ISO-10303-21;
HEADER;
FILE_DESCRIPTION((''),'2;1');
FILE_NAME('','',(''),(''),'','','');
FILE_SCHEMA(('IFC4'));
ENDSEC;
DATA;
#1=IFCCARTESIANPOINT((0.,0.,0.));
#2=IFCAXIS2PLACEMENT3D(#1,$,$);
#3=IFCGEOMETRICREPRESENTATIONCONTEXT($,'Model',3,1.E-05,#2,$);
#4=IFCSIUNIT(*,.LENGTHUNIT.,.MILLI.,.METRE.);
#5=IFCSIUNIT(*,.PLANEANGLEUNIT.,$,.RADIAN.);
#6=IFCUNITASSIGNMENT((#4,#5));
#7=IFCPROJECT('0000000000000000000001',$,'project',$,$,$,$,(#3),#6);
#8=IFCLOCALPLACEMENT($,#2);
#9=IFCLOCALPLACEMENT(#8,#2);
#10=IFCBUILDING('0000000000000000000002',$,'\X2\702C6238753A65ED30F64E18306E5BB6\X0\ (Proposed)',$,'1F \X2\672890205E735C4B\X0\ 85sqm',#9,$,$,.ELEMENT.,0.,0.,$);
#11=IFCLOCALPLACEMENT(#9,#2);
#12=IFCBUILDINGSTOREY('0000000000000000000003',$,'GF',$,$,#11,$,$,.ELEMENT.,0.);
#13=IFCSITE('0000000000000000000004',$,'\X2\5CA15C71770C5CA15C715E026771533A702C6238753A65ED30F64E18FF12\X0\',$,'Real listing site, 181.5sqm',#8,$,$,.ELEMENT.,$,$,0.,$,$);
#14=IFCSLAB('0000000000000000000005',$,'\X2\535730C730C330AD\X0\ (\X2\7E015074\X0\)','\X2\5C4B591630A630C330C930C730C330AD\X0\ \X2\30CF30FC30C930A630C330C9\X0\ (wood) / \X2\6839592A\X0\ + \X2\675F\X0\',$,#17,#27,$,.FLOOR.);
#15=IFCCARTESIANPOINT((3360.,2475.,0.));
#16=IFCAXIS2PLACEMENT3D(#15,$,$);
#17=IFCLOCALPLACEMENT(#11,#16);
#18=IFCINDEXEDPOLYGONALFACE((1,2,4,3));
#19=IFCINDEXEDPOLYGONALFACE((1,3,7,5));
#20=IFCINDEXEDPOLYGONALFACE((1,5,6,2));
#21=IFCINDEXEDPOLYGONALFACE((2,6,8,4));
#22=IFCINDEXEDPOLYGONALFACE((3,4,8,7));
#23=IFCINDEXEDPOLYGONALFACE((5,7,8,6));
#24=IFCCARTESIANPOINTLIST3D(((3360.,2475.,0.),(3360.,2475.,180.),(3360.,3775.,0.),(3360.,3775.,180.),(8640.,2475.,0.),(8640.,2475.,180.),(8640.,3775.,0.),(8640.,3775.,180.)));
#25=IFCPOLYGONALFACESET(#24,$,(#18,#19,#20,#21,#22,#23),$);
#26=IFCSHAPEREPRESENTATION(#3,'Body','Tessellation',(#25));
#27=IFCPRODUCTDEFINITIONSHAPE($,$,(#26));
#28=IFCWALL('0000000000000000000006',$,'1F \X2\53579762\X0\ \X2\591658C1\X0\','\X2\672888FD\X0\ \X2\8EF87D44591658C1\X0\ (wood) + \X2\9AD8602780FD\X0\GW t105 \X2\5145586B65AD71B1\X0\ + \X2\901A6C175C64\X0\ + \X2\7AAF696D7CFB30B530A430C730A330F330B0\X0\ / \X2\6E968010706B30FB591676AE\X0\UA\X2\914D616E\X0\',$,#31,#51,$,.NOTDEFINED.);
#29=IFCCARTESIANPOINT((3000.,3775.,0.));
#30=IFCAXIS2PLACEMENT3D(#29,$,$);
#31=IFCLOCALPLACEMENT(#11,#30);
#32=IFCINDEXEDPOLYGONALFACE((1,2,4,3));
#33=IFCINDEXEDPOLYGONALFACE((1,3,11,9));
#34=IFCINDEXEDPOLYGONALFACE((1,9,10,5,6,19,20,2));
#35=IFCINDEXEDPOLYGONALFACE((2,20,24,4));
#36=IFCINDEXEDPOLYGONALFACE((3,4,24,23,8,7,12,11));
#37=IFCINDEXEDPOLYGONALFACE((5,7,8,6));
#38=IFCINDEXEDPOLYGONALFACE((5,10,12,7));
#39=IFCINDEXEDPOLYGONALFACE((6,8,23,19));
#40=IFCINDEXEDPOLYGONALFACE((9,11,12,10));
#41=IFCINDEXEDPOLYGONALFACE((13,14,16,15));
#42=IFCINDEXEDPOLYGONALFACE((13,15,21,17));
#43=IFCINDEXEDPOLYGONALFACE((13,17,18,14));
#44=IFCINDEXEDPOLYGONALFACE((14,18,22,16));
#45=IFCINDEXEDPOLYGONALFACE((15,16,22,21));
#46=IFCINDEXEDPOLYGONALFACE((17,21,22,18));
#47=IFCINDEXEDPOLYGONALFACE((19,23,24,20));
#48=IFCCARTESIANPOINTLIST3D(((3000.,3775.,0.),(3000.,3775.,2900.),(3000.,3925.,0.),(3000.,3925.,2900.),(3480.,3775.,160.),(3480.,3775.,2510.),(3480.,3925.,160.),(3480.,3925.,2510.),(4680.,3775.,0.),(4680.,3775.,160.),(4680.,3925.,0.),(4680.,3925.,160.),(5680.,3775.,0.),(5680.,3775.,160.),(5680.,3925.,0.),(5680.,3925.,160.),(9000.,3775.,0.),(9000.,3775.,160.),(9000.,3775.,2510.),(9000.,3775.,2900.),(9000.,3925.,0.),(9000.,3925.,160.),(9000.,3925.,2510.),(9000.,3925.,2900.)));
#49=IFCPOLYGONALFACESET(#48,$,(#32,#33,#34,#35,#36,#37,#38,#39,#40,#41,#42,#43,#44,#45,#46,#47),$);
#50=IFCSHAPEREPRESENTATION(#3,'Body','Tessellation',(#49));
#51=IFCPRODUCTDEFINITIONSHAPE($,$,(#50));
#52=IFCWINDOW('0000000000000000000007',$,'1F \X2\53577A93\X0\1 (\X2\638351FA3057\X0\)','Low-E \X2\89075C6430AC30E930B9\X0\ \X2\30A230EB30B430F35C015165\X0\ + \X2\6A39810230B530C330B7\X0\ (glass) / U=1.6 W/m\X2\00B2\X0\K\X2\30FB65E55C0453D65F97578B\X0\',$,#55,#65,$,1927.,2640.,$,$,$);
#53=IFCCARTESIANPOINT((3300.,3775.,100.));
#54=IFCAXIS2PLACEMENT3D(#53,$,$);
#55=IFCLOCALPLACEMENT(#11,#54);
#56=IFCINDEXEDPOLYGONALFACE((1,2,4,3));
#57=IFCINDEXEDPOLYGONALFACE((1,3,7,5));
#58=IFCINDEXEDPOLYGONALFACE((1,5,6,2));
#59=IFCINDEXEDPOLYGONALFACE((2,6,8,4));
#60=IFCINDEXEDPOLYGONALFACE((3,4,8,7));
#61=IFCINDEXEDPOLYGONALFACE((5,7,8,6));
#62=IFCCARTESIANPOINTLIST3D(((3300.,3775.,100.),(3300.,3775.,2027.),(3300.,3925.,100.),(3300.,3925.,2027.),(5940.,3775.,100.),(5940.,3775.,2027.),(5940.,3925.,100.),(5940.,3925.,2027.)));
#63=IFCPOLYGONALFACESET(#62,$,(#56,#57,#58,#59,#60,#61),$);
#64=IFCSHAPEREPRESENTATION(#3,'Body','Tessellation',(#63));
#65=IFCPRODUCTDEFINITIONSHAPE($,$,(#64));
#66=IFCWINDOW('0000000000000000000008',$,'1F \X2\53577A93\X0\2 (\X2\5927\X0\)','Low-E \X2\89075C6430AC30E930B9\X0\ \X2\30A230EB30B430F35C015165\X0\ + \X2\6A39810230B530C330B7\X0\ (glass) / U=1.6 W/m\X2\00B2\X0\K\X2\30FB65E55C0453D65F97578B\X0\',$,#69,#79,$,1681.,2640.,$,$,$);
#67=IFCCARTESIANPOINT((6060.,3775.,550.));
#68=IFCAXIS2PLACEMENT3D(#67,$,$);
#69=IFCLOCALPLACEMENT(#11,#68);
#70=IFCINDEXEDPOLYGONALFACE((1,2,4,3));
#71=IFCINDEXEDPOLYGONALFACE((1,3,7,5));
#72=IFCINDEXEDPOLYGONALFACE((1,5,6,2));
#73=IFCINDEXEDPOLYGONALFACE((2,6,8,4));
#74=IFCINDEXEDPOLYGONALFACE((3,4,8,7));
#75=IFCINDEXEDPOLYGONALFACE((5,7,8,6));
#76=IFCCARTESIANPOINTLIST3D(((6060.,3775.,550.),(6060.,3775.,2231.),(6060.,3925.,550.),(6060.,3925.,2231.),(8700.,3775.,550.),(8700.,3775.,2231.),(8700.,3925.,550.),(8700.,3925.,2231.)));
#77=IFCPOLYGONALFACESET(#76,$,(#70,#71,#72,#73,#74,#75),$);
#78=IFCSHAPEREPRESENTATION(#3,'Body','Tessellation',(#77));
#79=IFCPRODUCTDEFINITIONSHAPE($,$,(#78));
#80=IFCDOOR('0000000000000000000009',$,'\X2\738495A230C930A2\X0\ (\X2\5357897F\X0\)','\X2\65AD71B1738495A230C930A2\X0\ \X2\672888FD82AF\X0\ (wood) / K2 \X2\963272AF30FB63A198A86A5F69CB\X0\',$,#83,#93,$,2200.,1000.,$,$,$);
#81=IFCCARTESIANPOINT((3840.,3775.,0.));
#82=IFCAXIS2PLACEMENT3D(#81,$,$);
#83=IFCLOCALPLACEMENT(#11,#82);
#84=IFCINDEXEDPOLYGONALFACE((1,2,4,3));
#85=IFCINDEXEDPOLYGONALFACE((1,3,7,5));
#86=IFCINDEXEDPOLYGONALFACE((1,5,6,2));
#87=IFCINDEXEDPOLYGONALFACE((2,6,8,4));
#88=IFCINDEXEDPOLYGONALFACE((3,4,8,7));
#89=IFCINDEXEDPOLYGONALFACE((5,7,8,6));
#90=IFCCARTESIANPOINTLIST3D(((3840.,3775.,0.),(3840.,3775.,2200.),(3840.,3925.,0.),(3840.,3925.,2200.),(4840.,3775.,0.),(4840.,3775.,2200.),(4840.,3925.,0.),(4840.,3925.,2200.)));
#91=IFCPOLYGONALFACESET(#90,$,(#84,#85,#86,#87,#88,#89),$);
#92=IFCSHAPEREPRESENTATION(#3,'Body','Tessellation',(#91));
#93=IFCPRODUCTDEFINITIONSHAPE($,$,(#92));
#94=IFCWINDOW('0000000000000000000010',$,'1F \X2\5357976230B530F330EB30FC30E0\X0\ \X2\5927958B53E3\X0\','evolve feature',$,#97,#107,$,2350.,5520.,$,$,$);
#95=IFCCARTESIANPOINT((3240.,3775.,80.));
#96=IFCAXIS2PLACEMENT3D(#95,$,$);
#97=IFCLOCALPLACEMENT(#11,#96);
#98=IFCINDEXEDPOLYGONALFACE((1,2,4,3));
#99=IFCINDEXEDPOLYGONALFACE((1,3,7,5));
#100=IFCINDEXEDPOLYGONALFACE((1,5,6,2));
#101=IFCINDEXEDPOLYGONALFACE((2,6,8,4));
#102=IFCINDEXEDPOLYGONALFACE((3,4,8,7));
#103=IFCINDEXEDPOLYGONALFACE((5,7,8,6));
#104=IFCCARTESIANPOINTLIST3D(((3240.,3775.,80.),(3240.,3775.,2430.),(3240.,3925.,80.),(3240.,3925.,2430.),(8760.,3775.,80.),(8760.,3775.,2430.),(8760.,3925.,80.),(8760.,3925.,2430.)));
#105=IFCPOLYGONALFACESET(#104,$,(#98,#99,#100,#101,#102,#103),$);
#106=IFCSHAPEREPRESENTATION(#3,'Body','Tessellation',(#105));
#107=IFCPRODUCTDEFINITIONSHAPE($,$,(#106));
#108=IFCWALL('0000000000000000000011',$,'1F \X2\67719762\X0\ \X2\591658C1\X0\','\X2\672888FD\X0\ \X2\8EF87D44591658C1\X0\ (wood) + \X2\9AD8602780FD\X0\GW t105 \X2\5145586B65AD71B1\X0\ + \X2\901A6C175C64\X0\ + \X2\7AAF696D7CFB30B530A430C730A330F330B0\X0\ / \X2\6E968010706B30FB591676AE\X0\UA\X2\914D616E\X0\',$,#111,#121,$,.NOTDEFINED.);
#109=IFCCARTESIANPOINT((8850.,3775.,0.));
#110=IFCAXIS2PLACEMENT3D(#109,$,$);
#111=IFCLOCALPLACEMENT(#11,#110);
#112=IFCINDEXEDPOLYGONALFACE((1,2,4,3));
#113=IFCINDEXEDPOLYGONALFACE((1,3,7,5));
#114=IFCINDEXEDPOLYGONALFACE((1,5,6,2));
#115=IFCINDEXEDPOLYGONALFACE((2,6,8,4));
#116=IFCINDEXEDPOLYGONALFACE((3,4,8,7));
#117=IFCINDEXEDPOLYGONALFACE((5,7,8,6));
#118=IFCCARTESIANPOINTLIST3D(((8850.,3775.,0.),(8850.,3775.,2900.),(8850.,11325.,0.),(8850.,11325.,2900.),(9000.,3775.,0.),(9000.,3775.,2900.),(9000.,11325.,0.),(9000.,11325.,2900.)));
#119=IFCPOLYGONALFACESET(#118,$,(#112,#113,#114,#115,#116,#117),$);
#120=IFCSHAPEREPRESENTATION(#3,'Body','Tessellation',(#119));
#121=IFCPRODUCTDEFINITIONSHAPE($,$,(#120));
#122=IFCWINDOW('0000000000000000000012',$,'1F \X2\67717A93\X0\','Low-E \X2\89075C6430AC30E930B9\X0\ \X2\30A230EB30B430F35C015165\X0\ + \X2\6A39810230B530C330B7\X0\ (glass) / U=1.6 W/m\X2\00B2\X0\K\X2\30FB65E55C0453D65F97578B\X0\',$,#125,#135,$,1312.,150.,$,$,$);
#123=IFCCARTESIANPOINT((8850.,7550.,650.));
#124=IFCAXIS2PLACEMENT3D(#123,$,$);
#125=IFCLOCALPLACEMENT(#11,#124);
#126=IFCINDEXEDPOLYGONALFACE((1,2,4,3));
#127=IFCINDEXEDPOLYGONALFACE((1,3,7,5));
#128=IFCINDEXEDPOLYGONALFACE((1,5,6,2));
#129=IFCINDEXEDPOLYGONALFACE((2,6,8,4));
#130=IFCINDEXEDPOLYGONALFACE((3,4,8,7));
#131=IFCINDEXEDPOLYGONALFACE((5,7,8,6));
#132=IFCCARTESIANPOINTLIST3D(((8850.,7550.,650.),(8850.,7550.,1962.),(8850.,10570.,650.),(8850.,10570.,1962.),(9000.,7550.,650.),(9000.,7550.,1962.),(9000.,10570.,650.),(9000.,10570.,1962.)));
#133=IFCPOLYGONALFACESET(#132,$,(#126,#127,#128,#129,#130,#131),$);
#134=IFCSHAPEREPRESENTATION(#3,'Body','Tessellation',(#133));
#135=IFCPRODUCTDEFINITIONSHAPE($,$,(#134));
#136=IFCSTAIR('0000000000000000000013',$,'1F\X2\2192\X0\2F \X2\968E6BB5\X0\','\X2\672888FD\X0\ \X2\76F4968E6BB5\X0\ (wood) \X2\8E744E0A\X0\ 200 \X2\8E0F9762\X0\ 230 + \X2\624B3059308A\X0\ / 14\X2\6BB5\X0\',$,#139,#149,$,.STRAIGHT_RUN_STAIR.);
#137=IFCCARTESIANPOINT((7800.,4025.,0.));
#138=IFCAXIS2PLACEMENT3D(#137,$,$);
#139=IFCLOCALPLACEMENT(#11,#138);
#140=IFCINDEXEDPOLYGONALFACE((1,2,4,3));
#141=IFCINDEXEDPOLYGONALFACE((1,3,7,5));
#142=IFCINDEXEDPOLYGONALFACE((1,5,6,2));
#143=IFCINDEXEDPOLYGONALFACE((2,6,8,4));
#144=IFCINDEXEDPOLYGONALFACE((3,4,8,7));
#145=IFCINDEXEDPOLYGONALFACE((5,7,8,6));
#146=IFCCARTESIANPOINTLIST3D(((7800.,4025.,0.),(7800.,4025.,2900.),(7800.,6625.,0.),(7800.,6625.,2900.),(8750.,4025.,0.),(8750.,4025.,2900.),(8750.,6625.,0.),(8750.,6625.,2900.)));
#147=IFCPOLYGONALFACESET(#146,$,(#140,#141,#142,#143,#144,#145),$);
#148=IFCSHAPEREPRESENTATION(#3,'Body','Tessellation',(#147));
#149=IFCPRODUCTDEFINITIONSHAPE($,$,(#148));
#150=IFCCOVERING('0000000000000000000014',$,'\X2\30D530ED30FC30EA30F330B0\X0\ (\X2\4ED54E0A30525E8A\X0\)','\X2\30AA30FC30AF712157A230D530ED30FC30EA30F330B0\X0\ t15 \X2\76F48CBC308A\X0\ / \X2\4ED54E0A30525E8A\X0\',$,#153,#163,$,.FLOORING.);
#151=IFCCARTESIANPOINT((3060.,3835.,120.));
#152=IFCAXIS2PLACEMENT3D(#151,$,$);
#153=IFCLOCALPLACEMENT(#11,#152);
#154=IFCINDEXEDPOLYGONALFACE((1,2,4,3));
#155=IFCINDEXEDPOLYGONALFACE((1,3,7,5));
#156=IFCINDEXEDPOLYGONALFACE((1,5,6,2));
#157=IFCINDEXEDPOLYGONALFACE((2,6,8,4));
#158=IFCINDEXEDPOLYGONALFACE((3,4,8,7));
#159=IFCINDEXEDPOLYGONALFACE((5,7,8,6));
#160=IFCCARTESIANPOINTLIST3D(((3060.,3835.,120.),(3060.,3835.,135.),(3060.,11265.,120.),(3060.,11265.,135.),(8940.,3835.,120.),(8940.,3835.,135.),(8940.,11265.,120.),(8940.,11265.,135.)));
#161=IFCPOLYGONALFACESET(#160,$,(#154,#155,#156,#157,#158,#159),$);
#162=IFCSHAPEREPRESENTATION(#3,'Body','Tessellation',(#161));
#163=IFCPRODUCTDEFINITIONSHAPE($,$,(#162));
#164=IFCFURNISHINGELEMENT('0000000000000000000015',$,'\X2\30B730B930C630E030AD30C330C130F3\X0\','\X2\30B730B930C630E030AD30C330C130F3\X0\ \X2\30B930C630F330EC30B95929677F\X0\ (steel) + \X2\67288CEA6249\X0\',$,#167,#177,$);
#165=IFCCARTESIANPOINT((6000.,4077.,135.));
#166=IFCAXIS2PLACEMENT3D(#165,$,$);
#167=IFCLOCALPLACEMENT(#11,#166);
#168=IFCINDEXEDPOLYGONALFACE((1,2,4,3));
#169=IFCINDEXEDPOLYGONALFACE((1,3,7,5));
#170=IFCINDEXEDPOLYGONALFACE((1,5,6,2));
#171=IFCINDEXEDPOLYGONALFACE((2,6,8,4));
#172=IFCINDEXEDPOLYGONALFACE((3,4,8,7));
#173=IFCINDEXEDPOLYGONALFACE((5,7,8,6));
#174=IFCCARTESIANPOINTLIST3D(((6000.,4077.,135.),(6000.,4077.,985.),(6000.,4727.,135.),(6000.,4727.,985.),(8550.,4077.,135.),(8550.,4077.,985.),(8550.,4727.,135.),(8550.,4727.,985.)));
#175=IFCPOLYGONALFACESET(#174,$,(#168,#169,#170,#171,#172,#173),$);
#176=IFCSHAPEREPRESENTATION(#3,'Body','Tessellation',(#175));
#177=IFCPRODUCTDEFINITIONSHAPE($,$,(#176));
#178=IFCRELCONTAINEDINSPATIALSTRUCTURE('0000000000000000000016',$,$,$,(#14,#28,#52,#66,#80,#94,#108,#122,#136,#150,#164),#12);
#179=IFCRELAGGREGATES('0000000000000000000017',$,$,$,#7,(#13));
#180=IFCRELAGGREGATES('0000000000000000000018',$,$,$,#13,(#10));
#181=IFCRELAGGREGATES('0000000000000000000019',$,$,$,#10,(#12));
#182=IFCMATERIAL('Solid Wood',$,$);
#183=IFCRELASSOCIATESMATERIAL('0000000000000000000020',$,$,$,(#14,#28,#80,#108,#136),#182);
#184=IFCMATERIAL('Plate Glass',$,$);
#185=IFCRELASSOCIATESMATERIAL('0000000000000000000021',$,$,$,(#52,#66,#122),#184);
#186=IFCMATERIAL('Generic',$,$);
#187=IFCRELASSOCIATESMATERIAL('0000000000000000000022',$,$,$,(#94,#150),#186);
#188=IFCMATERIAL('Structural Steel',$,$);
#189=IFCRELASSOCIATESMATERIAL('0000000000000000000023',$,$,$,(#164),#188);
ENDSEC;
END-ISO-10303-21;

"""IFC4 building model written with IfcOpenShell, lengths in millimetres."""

from ifc_helpers import new_model, si_unit, frame, frame_2d, origin, place, context, project, spatial, rectangle, extrude, material, element, fill, save


model = new_model("IFC4")

# Units and contexts
model_context = context("Model", 3, precision=1e-05, world=origin())
ifc_project = project(units=[si_unit("LENGTHUNIT", "METRE", prefix="MILLI"), si_unit("PLANEANGLEUNIT", "RADIAN")], contexts=[model_context])

# Site, building, storey
site_placement = place(None, origin())
site = spatial("IfcSite", under=ifc_project, at=site_placement, Name="岡山県岡山市東区瀬戸町旭ヶ丘２", ObjectType="Real listing site, 181.5sqm", CompositionType="ELEMENT", RefElevation=0.0)
building_placement = place(site_placement, origin())
building = spatial("IfcBuilding", under=site, at=building_placement, Name="瀬戸町旭ヶ丘の家 (Proposed)", ObjectType="1F 木造平屋 85sqm", CompositionType="ELEMENT", ElevationOfRefHeight=0.0, ElevationOfTerrain=0.0)
storey_placement = place(building_placement, origin())
storey = spatial("IfcBuildingStorey", under=building, at=storey_placement, Name="GF", CompositionType="ELEMENT", Elevation=0.0)

# Slab
ifc_material_1 = material(Name="Solid Wood")
slab_1_placement = place(storey_placement, frame((3360.0, 2475.0, 0.0)))
element("IfcSlab", 1, at=slab_1_placement, inside=storey, material=ifc_material_1, Name="南デッキ (縁側)", Description="屋外ウッドデッキ ハードウッド (wood) / 根太 + 束", PredefinedType="FLOOR", context=model_context, shape_type="SweptSolid", body=[
    extrude(rectangle(XDim=5280.0, YDim=1300.0, at=frame_2d((2640.0, 650.0))), frame((3360.0, 2475.0, 0.0)), (0.0, 0.0, 1.0), 180.0),
])
ifc_material_2 = material(Name="Generic")

# Wall, openings, windows, door
wall_1_placement = place(storey_placement, frame((3000.0, 3775.0, 0.0)))
wall_1 = element("IfcWall", 2, at=wall_1_placement, inside=storey, material=ifc_material_1, Name="1F 南面 外壁", Description="木製 軸組外壁 (wood) + 高性能GW t105 充填断熱 + 通気層 + 窯業系サイディング / 準耐火・外皮UA配慮", PredefinedType="NOTDEFINED", context=model_context, shape_type="SweptSolid", body=[
    extrude(rectangle(XDim=6000.0, YDim=150.0, at=frame_2d((3000.0, 75.0))), frame((3000.0, 3775.0, 0.0)), (0.0, 0.0, 1.0), 2900.0),
])
opening_1_placement = place(storey_placement, frame((3300.0, 3775.0, 100.0)))
opening_1 = element("IfcOpeningElement", 3, at=opening_1_placement, cuts=wall_1, PredefinedType="NOTDEFINED", context=model_context, shape_type="SweptSolid", body=[
    extrude(rectangle(XDim=2640.0, YDim=150.0, at=frame_2d((1320.0, 75.0))), frame((3300.0, 3775.0, 100.0)), (0.0, 0.0, 1.0), 1927.0),
])
opening_2_placement = place(storey_placement, frame((6060.0, 3775.0, 550.0)))
opening_2 = element("IfcOpeningElement", 4, at=opening_2_placement, cuts=wall_1, PredefinedType="NOTDEFINED", context=model_context, shape_type="SweptSolid", body=[
    extrude(rectangle(XDim=2640.0, YDim=150.0, at=frame_2d((1320.0, 75.0))), frame((6060.0, 3775.0, 550.0)), (0.0, 0.0, 1.0), 1681.0),
])
opening_3_placement = place(storey_placement, frame((3840.0, 3775.0, 0.0)))
opening_3 = element("IfcOpeningElement", 5, at=opening_3_placement, cuts=wall_1, PredefinedType="NOTDEFINED", context=model_context, shape_type="SweptSolid", body=[
    extrude(rectangle(XDim=1000.0, YDim=150.0, at=frame_2d((500.0, 75.0))), frame((3840.0, 3775.0, 0.0)), (0.0, 0.0, 1.0), 2200.0),
])
opening_4_placement = place(storey_placement, frame((3240.0, 3775.0, 80.0)))
opening_4 = element("IfcOpeningElement", 6, at=opening_4_placement, cuts=wall_1, PredefinedType="NOTDEFINED", context=model_context, shape_type="SweptSolid", body=[
    extrude(rectangle(XDim=5520.0, YDim=150.0, at=frame_2d((2760.0, 75.0))), frame((3240.0, 3775.0, 80.0)), (0.0, 0.0, 1.0), 2350.0),
])
ifc_material_3 = material(Name="Plate Glass")
window_1_placement = place(storey_placement, frame((3300.0, 3775.0, 100.0)))
window_1 = element("IfcWindow", 7, at=window_1_placement, inside=storey, material=ifc_material_3, Name="1F 南窓1 (掃出し)", Description="Low-E 複層ガラス アルゴン封入 + 樹脂サッシ (glass) / U=1.6 W/m²K・日射取得型", OverallHeight=1927.0, OverallWidth=2640.0, context=model_context, shape_type="SweptSolid", body=[
    extrude(rectangle(XDim=2640.0, YDim=150.0, at=frame_2d((1320.0, 75.0))), frame((3300.0, 3775.0, 100.0)), (0.0, 0.0, 1.0), 1927.0),
])
fill(opening_1, window_1)
window_2_placement = place(storey_placement, frame((6060.0, 3775.0, 550.0)))
window_2 = element("IfcWindow", 8, at=window_2_placement, inside=storey, material=ifc_material_3, Name="1F 南窓2 (大)", Description="Low-E 複層ガラス アルゴン封入 + 樹脂サッシ (glass) / U=1.6 W/m²K・日射取得型", OverallHeight=1681.0, OverallWidth=2640.0, context=model_context, shape_type="SweptSolid", body=[
    extrude(rectangle(XDim=2640.0, YDim=150.0, at=frame_2d((1320.0, 75.0))), frame((6060.0, 3775.0, 550.0)), (0.0, 0.0, 1.0), 1681.0),
])
fill(opening_2, window_2)
door_placement = place(storey_placement, frame((3840.0, 3775.0, 0.0)))
door = element("IfcDoor", 9, at=door_placement, inside=storey, material=ifc_material_1, Name="玄関ドア (南西)", Description="断熱玄関ドア 木製芯 (wood) / K2 防犯・採風機構", OverallHeight=2200.0, OverallWidth=1000.0, context=model_context, shape_type="SweptSolid", body=[
    extrude(rectangle(XDim=1000.0, YDim=150.0, at=frame_2d((500.0, 75.0))), frame((3840.0, 3775.0, 0.0)), (0.0, 0.0, 1.0), 2200.0),
])
fill(opening_3, door)
window_3_placement = place(storey_placement, frame((3240.0, 3775.0, 80.0)))
window_3 = element("IfcWindow", 10, at=window_3_placement, inside=storey, material=ifc_material_2, Name="1F 南面サンルーム 大開口", Description="evolve feature", OverallHeight=2350.0, OverallWidth=5520.0, context=model_context, shape_type="SweptSolid", body=[
    extrude(rectangle(XDim=5520.0, YDim=150.0, at=frame_2d((2760.0, 75.0))), frame((3240.0, 3775.0, 80.0)), (0.0, 0.0, 1.0), 2350.0),
])
fill(opening_4, window_3)

# Wall, opening, window
wall_2_placement = place(storey_placement, frame((8850.0, 3775.0, 0.0)))
wall_2 = element("IfcWall", 11, at=wall_2_placement, inside=storey, material=ifc_material_1, Name="1F 東面 外壁", Description="木製 軸組外壁 (wood) + 高性能GW t105 充填断熱 + 通気層 + 窯業系サイディング / 準耐火・外皮UA配慮", PredefinedType="NOTDEFINED", context=model_context, shape_type="SweptSolid", body=[
    extrude(rectangle(XDim=150.0, YDim=7550.0, at=frame_2d((75.0, 3775.0))), frame((8850.0, 3775.0, 0.0)), (0.0, 0.0, 1.0), 2900.0),
])
opening_5_placement = place(storey_placement, frame((8850.0, 7550.0, 650.0)))
opening_5 = element("IfcOpeningElement", 12, at=opening_5_placement, cuts=wall_2, PredefinedType="NOTDEFINED", context=model_context, shape_type="SweptSolid", body=[
    extrude(rectangle(XDim=150.0, YDim=3020.0, at=frame_2d((75.0, 1510.0))), frame((8850.0, 7550.0, 650.0)), (0.0, 0.0, 1.0), 1312.0),
])
window_4_placement = place(storey_placement, frame((8850.0, 7550.0, 650.0)))
window_4 = element("IfcWindow", 13, at=window_4_placement, inside=storey, material=ifc_material_3, Name="1F 東窓", Description="Low-E 複層ガラス アルゴン封入 + 樹脂サッシ (glass) / U=1.6 W/m²K・日射取得型", OverallHeight=1312.0, OverallWidth=150.0, context=model_context, shape_type="SweptSolid", body=[
    extrude(rectangle(XDim=150.0, YDim=3020.0, at=frame_2d((75.0, 1510.0))), frame((8850.0, 7550.0, 650.0)), (0.0, 0.0, 1.0), 1312.0),
])
fill(opening_5, window_4)

# Stair
stair_placement = place(storey_placement, frame((7800.0, 4025.0, 0.0)))
element("IfcStair", 14, at=stair_placement, inside=storey, material=ifc_material_1, Name="1F→2F 階段", Description="木製 直階段 (wood) 蹴上 200 踏面 230 + 手すり / 14段", PredefinedType="STRAIGHT_RUN_STAIR", context=model_context, shape_type="SweptSolid", body=[
    extrude(rectangle(XDim=950.0, YDim=2600.0, at=frame_2d((475.0, 1300.0))), frame((7800.0, 4025.0, 0.0)), (0.0, 0.0, 1.0), 2900.0),
])

# Covering
covering_placement = place(storey_placement, frame((3060.0, 3835.0, 120.0)))
element("IfcCovering", 15, at=covering_placement, inside=storey, material=ifc_material_2, Name="フローリング (仕上げ床)", Description="オーク無垢フローリング t15 直貼り / 仕上げ床", PredefinedType="FLOORING", context=model_context, shape_type="SweptSolid", body=[
    extrude(rectangle(XDim=5880.0, YDim=7430.0, at=frame_2d((2940.0, 3715.0))), frame((3060.0, 3835.0, 120.0)), (0.0, 0.0, 1.0), 15.0),
])

# Furnishing element
ifc_material_4 = material(Name="Structural Steel")
furnishing_placement = place(storey_placement, frame((6000.0, 4077.0, 135.0)))
element("IfcFurnishingElement", 16, at=furnishing_placement, inside=storey, material=ifc_material_4, Name="システムキッチン", Description="システムキッチン ステンレス天板 (steel) + 木質扉", context=model_context, shape_type="SweptSolid", body=[
    extrude(rectangle(XDim=2550.0, YDim=650.0, at=frame_2d((1275.0, 325.0))), frame((6000.0, 4077.0, 135.0)), (0.0, 0.0, 1.0), 850.0),
])

save(model, "model.ifc")
